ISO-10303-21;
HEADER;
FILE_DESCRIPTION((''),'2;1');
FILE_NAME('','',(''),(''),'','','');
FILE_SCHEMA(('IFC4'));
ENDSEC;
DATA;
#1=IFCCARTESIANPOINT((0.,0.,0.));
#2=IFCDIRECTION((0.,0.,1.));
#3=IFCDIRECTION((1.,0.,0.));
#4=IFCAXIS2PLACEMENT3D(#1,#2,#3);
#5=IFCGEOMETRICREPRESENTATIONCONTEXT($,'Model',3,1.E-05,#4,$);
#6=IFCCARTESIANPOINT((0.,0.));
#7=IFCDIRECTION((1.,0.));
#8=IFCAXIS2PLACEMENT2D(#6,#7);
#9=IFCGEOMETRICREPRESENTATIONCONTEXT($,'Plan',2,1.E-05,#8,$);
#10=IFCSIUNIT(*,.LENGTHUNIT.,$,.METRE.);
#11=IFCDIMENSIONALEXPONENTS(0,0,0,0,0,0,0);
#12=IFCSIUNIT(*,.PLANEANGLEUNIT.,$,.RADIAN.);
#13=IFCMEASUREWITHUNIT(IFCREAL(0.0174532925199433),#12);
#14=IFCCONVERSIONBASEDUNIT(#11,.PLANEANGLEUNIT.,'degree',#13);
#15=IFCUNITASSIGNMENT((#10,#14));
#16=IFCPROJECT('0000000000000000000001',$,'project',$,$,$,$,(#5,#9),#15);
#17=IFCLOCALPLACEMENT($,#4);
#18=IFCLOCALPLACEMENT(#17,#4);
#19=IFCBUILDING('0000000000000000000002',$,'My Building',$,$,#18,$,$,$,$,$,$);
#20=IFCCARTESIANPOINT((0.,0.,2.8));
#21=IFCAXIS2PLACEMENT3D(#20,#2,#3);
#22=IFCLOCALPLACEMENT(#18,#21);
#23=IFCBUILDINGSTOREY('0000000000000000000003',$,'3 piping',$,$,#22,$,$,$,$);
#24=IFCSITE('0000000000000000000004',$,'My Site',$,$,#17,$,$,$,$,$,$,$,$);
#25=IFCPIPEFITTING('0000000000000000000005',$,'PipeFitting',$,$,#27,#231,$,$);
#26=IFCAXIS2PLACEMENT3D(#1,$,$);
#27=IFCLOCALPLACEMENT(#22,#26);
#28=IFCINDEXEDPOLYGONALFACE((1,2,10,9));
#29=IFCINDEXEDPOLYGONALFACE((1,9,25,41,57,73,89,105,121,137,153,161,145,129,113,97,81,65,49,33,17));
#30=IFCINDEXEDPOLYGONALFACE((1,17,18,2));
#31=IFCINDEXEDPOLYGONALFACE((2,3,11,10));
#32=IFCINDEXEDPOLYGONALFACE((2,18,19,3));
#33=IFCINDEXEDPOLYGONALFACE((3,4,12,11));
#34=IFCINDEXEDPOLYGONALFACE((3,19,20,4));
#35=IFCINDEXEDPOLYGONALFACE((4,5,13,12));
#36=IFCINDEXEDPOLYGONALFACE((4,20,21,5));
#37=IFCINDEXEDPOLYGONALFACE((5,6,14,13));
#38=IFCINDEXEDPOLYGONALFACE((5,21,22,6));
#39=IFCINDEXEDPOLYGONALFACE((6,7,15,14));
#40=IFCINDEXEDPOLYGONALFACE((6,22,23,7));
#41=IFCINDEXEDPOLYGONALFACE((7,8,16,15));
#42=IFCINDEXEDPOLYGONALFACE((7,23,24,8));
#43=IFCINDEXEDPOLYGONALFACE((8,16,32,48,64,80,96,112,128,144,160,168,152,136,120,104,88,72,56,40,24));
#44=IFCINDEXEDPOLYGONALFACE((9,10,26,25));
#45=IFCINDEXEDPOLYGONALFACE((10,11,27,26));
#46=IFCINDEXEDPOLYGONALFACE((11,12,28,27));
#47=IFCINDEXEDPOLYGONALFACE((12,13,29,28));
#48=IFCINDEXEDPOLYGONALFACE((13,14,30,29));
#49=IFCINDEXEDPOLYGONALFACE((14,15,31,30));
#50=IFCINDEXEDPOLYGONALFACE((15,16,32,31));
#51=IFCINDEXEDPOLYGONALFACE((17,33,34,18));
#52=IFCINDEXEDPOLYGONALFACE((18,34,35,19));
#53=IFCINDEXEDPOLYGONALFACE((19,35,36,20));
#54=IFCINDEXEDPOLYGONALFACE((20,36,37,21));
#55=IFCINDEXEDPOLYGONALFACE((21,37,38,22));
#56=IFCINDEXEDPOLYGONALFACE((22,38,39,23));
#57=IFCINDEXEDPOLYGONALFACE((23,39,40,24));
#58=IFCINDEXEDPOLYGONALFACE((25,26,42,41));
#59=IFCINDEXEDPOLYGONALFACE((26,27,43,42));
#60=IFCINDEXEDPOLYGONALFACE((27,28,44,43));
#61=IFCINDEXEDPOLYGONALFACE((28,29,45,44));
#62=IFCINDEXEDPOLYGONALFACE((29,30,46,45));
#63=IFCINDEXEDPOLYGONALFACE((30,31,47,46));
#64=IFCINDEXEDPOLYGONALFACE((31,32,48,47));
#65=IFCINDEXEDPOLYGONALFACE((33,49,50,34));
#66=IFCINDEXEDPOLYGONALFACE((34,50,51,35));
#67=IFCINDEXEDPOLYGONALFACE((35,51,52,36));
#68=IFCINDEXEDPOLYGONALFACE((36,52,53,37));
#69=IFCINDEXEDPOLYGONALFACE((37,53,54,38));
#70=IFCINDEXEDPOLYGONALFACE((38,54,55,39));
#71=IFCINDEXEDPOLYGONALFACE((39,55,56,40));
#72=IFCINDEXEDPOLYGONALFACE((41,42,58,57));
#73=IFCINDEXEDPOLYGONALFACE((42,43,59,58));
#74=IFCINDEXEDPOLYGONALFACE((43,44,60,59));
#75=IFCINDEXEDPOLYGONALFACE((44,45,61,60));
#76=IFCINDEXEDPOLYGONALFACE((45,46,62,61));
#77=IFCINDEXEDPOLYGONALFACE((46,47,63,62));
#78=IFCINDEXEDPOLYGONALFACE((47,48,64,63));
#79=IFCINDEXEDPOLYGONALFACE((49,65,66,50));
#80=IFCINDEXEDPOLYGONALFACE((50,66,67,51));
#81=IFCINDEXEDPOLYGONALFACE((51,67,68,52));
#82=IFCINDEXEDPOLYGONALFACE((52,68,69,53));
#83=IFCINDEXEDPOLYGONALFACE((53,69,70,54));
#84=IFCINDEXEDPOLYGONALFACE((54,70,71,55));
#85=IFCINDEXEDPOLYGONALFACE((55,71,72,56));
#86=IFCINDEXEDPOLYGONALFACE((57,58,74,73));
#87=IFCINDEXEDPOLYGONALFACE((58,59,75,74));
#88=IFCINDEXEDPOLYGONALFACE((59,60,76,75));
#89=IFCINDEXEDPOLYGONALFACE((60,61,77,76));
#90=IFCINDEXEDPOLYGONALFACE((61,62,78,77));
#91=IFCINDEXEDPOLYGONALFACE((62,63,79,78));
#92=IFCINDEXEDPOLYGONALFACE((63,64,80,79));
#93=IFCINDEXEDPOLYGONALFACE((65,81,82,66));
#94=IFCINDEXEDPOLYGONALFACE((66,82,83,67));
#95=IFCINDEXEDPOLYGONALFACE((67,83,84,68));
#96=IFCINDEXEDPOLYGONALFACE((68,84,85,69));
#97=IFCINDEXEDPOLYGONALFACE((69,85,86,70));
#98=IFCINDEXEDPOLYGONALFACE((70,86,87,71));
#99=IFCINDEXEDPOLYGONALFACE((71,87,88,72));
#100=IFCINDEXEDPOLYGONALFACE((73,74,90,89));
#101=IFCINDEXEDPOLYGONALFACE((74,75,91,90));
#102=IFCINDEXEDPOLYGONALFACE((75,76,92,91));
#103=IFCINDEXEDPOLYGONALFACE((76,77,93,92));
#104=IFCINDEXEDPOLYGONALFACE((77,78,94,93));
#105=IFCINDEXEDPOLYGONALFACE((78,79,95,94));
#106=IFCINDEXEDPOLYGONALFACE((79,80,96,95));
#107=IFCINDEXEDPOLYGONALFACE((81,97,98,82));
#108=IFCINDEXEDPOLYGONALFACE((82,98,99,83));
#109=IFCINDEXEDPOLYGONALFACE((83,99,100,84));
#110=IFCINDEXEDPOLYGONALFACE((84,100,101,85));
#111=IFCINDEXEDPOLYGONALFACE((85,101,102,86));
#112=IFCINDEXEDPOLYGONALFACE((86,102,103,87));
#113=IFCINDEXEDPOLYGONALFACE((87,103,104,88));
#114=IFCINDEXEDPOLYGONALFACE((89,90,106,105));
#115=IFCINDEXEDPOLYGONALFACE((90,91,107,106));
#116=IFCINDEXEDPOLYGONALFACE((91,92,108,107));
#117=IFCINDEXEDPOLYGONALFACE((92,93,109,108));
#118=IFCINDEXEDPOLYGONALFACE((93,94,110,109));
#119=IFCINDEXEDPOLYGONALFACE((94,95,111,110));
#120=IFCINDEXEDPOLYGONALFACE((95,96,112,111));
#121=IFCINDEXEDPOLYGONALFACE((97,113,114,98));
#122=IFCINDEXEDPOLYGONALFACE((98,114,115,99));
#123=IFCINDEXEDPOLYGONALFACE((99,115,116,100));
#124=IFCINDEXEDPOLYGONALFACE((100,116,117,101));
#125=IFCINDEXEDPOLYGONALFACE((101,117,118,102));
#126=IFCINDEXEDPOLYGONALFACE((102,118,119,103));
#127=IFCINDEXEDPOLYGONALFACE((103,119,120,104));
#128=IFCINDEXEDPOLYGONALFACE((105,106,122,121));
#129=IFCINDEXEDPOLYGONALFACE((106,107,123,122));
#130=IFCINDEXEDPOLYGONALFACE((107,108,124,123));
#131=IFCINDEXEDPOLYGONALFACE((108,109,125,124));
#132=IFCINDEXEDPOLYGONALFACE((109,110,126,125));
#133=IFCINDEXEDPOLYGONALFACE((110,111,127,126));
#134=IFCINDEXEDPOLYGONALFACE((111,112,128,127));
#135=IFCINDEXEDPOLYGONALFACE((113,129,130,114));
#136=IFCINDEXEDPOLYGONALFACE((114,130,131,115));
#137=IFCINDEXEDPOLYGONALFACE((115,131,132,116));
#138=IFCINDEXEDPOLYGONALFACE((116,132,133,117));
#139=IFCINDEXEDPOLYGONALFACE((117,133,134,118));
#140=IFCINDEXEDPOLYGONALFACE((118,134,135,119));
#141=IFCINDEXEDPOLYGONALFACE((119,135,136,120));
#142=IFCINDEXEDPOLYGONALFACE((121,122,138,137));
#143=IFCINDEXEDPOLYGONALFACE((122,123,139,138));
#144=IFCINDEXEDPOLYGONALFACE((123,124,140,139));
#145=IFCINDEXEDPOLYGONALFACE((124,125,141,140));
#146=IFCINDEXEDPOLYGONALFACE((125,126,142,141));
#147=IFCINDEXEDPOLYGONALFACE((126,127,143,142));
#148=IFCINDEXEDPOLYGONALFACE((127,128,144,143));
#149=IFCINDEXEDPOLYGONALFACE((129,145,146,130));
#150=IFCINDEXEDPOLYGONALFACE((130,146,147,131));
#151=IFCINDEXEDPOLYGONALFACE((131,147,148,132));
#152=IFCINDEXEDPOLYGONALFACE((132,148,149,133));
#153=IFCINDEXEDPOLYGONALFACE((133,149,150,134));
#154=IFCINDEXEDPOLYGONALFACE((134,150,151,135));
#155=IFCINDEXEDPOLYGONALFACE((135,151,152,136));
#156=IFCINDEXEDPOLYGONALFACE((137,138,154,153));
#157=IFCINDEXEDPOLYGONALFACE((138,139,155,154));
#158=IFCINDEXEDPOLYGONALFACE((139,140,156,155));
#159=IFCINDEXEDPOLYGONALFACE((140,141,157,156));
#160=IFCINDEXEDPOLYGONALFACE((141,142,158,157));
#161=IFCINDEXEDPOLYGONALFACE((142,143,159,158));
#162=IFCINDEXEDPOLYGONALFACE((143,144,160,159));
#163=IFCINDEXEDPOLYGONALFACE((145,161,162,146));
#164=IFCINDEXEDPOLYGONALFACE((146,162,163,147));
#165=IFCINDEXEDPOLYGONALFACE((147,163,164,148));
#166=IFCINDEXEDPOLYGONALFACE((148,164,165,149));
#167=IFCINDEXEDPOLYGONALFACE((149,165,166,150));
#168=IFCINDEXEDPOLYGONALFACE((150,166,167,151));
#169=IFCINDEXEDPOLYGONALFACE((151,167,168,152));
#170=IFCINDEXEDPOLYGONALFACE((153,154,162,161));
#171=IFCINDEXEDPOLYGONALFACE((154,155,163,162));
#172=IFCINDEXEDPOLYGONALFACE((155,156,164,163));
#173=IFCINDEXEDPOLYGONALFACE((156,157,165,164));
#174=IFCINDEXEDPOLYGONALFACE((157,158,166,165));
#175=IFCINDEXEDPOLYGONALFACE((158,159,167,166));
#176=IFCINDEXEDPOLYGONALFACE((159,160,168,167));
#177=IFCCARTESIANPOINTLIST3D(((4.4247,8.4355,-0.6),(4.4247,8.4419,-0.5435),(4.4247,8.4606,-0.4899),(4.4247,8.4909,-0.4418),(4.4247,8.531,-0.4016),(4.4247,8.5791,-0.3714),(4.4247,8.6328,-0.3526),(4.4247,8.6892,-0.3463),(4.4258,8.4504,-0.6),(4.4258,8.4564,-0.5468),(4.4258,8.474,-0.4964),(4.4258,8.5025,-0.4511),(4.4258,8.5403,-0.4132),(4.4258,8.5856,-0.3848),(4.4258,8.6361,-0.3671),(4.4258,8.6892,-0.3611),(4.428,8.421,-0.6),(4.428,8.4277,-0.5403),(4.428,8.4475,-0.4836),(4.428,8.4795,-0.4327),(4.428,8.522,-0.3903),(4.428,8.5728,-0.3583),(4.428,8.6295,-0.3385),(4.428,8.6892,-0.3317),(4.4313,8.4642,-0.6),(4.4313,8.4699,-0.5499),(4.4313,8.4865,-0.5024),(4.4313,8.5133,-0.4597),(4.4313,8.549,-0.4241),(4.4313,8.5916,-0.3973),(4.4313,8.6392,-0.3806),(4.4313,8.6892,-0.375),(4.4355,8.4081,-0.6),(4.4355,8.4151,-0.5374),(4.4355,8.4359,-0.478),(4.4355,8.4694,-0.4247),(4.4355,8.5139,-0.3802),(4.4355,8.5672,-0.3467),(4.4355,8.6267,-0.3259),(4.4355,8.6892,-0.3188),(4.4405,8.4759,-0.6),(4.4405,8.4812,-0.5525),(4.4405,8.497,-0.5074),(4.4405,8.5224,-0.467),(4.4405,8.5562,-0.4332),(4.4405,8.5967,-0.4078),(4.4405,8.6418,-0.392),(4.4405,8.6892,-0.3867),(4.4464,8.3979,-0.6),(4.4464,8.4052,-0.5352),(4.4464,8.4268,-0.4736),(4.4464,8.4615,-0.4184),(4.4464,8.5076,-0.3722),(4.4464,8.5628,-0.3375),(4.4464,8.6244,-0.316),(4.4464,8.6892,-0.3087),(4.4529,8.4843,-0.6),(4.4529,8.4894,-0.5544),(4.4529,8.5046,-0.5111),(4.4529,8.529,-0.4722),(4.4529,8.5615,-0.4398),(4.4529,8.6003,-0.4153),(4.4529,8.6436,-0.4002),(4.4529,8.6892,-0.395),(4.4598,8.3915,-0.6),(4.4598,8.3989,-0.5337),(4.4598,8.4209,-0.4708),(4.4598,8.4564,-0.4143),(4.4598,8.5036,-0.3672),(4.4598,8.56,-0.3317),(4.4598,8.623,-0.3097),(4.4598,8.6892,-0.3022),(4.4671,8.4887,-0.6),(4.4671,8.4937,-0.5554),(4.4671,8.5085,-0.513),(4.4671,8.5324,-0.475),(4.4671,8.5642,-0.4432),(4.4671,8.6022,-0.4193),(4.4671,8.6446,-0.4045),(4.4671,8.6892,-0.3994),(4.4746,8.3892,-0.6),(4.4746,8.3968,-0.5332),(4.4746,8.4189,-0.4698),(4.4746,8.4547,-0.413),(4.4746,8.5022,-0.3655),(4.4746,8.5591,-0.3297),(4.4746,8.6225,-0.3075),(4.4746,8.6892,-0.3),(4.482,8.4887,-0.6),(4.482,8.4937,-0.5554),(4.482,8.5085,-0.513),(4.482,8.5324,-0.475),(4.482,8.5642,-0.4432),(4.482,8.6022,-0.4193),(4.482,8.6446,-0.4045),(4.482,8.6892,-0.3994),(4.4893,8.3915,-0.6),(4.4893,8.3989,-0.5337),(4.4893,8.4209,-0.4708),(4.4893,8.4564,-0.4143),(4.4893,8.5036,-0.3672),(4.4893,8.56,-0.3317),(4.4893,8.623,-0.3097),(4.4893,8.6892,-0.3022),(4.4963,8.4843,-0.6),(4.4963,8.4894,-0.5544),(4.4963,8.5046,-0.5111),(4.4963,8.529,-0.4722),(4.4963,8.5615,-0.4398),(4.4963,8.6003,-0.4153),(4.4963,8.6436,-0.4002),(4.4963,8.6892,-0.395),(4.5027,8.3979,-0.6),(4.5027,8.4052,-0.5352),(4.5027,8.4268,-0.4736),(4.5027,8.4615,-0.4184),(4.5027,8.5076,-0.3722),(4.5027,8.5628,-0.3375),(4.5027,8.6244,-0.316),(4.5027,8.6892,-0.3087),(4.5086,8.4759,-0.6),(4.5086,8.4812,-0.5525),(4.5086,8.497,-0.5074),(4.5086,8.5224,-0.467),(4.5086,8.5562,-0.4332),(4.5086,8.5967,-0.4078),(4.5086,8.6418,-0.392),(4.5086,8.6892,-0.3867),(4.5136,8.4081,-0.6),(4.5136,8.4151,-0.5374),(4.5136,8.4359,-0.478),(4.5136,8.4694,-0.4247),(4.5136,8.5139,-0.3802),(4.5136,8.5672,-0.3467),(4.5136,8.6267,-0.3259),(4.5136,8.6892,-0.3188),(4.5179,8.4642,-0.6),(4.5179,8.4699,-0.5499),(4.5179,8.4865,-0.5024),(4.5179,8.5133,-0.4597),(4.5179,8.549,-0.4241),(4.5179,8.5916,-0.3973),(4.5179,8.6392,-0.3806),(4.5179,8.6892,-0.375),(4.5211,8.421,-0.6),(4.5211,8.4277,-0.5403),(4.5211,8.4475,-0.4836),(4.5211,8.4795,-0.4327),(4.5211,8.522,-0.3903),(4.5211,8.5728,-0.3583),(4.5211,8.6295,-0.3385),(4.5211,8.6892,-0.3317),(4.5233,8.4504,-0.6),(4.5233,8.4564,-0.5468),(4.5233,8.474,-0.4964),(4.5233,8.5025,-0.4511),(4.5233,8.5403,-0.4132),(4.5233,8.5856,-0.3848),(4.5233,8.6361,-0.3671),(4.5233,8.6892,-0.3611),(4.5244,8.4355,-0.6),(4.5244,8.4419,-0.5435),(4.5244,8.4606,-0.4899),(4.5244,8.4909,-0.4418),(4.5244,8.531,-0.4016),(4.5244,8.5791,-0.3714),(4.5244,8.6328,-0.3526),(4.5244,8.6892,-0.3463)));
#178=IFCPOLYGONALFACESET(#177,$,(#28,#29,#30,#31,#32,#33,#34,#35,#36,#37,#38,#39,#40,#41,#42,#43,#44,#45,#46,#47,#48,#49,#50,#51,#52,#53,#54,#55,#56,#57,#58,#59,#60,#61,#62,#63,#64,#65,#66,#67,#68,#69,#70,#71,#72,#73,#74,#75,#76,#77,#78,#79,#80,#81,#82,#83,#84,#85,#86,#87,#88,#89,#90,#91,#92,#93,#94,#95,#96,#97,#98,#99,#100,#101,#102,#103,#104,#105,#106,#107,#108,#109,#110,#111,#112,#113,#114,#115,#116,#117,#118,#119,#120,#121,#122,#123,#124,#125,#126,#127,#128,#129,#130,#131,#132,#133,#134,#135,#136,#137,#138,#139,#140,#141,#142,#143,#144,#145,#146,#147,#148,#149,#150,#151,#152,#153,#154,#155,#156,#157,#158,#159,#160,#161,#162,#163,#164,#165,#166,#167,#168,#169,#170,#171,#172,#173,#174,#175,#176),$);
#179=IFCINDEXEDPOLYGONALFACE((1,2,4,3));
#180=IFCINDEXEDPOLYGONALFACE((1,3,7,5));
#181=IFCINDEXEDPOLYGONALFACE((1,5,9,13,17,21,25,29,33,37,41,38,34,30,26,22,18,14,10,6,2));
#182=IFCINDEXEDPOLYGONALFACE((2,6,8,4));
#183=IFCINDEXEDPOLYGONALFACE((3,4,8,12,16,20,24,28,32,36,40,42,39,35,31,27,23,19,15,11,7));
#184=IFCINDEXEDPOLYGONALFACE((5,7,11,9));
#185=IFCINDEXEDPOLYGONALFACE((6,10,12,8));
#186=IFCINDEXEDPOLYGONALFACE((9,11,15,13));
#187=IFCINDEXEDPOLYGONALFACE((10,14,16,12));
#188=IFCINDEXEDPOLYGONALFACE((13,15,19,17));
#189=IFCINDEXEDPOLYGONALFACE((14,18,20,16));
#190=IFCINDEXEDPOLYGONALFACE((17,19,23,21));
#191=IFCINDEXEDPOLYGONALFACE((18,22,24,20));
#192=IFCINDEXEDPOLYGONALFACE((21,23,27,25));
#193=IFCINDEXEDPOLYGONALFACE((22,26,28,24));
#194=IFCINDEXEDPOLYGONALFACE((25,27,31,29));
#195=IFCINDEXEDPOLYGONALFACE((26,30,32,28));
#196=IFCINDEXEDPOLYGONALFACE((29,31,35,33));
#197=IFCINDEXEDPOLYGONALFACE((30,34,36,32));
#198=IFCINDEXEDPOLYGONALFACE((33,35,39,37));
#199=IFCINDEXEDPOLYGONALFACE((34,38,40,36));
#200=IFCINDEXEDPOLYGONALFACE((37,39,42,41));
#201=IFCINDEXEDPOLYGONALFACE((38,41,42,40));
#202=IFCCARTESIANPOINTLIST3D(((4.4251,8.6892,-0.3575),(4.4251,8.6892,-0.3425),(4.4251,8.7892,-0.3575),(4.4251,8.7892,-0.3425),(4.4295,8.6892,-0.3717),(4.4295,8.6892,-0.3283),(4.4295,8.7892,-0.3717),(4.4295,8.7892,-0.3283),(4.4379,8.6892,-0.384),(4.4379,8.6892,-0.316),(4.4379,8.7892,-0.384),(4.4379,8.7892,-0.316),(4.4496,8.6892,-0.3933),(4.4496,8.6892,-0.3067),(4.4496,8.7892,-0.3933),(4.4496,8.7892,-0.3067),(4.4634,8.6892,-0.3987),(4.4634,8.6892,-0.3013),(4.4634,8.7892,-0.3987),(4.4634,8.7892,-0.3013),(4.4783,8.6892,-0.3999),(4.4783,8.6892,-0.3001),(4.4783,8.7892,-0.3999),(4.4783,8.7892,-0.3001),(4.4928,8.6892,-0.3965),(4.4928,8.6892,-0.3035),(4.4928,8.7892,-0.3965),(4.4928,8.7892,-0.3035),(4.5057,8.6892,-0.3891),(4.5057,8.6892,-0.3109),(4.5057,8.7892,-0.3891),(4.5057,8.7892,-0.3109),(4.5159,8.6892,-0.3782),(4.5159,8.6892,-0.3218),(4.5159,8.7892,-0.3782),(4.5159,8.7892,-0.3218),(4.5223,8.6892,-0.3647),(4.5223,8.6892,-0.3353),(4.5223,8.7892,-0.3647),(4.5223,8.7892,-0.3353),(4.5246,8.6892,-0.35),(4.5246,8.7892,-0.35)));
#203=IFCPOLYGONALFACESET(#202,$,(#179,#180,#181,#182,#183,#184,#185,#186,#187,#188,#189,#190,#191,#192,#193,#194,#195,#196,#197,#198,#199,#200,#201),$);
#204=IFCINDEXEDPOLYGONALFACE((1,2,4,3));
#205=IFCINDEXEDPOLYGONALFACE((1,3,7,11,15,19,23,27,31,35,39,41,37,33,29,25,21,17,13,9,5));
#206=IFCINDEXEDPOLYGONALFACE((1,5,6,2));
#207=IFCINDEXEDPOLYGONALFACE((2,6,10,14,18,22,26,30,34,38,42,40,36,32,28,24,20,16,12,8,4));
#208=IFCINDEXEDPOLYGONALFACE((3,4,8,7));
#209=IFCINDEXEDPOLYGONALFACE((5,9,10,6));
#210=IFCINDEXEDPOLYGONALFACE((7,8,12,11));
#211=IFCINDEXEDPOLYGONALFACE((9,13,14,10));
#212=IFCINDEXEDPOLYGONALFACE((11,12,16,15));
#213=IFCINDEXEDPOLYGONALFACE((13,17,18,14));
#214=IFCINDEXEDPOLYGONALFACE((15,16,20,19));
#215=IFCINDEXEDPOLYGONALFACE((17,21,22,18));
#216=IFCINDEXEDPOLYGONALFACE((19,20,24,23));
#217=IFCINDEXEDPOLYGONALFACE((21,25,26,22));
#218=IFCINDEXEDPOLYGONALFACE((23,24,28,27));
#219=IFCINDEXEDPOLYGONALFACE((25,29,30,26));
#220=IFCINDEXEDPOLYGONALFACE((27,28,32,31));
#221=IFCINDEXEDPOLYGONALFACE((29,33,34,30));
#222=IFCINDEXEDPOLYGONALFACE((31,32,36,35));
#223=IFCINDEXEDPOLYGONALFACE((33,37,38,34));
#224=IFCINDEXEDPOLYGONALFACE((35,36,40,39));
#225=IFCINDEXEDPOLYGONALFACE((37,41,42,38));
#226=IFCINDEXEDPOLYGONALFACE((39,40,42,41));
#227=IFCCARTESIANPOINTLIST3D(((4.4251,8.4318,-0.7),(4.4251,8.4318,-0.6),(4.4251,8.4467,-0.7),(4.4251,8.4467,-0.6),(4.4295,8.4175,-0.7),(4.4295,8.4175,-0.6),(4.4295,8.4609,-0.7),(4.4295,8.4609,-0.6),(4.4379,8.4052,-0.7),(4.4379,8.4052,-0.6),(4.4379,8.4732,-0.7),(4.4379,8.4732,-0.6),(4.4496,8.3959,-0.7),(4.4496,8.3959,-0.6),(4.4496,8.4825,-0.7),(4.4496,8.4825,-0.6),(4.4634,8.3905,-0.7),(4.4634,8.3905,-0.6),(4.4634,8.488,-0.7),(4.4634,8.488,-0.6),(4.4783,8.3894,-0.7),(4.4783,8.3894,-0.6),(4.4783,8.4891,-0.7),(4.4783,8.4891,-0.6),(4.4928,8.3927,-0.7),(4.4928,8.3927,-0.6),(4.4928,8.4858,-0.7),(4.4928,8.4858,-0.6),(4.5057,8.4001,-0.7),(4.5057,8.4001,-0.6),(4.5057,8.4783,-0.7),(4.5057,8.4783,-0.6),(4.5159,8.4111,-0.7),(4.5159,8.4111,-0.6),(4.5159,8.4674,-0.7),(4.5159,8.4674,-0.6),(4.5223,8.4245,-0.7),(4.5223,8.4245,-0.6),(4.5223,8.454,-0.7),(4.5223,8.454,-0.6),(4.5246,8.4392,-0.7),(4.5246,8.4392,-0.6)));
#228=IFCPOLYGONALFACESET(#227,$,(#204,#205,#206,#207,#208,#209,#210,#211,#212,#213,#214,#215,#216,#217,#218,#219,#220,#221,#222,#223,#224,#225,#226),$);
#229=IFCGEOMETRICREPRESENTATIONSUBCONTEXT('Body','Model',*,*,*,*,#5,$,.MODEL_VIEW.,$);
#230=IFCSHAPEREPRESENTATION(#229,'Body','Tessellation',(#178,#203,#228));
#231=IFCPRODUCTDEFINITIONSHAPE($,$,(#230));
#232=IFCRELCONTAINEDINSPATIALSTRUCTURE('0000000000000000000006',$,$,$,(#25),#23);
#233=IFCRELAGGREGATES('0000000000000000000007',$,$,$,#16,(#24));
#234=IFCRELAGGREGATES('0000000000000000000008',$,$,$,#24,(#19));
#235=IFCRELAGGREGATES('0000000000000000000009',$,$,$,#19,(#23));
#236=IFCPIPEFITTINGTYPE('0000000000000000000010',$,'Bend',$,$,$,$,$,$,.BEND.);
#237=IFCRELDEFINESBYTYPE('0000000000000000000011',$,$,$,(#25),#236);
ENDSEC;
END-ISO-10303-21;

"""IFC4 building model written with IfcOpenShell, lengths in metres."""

from ifc_helpers import new_model, entity, si_unit, converted_unit, frame, origin_with_axes, origin_2d_with_axis, place, context, subcontext, project, spatial, circle, extrude, source, transform, mapped, type_object, type_shapes, element, save


model = new_model("IFC4")

# Units and contexts
model_context = context("Model", 3, precision=1e-05, world=origin_with_axes())
plan_context = context("Plan", 2, precision=1e-05, world=origin_2d_with_axis())
body_context = subcontext(model_context, "Body", "Model", "MODEL_VIEW")
ifc_project = project(units=[si_unit("LENGTHUNIT", "METRE"), converted_unit("PLANEANGLEUNIT", "degree", entity("IfcReal", 0.0174532925199433), si_unit("PLANEANGLEUNIT", "RADIAN"), dimensions=[0, 0, 0, 0, 0, 0, 0])], contexts=[model_context, plan_context])

# Site, building, storey
site_placement = place(None, origin_with_axes())
site = spatial("IfcSite", under=ifc_project, at=site_placement, Name="My Site")
building_placement = place(site_placement, origin_with_axes())
building = spatial("IfcBuilding", under=site, at=building_placement, Name="My Building")
storey_placement = place(building_placement, frame((0.0, 0.0, 2.8), z_axis=(0.0, 0.0, 1.0), x_axis=(1.0, 0.0, 0.0)))
storey = spatial("IfcBuildingStorey", under=building, at=storey_placement, Name="3 piping")

# Pipe fitting
pipe_fitting_type_1 = type_object("IfcPipeFittingType", Name="Bend", PredefinedType="BEND")
shared_shape = source(origin_with_axes(), body_context, "Body", "SolidModel", [
    entity("IfcSweptDiskSolid", entity("IfcIndexedPolyCurve", entity("IfcCartesianPointList3D", [[0.0, 0.0, 0.1], [0.0, -0.0732, 0.2768], [0.0, -0.25, 0.35]]), [entity("IfcArcIndex", [1, 2, 3])]), 0.05),
    extrude(circle(Radius=0.05), origin_with_axes(), (0.0, 0.0, 1.0), 0.1),
    extrude(circle(Radius=0.05), frame((0.0, -0.25, 0.35), z_axis=(0.0, -1.0, 0.0), x_axis=(1.0, 0.0, 0.0)), (0.0, 0.0, 1.0), 0.1),
])
type_shapes(pipe_fitting_type_1, [shared_shape])
for number, where, z_axis, x_axis, name in (
    (1, (4.4746, 8.7892, -0.35), (0.0, -1.0, 0.0), (1.0, 0.0, 0.0), "PipeFitting"),
):
    element("IfcPipeFitting", number, at=place(storey_placement, frame(where, z_axis=z_axis, x_axis=x_axis)), inside=storey, type_object=pipe_fitting_type_1, Name=name, context=body_context, shape_type="MappedRepresentation", body=[
        mapped(shared_shape, transform((0.0, 0.0, 0.0), x_axis=(1.0, 0.0, 0.0), y_axis=(0.0, 1.0, 0.0), z_axis=(0.0, 0.0, 1.0), scale=1.0)),
    ])

save(model, "model.ifc")
